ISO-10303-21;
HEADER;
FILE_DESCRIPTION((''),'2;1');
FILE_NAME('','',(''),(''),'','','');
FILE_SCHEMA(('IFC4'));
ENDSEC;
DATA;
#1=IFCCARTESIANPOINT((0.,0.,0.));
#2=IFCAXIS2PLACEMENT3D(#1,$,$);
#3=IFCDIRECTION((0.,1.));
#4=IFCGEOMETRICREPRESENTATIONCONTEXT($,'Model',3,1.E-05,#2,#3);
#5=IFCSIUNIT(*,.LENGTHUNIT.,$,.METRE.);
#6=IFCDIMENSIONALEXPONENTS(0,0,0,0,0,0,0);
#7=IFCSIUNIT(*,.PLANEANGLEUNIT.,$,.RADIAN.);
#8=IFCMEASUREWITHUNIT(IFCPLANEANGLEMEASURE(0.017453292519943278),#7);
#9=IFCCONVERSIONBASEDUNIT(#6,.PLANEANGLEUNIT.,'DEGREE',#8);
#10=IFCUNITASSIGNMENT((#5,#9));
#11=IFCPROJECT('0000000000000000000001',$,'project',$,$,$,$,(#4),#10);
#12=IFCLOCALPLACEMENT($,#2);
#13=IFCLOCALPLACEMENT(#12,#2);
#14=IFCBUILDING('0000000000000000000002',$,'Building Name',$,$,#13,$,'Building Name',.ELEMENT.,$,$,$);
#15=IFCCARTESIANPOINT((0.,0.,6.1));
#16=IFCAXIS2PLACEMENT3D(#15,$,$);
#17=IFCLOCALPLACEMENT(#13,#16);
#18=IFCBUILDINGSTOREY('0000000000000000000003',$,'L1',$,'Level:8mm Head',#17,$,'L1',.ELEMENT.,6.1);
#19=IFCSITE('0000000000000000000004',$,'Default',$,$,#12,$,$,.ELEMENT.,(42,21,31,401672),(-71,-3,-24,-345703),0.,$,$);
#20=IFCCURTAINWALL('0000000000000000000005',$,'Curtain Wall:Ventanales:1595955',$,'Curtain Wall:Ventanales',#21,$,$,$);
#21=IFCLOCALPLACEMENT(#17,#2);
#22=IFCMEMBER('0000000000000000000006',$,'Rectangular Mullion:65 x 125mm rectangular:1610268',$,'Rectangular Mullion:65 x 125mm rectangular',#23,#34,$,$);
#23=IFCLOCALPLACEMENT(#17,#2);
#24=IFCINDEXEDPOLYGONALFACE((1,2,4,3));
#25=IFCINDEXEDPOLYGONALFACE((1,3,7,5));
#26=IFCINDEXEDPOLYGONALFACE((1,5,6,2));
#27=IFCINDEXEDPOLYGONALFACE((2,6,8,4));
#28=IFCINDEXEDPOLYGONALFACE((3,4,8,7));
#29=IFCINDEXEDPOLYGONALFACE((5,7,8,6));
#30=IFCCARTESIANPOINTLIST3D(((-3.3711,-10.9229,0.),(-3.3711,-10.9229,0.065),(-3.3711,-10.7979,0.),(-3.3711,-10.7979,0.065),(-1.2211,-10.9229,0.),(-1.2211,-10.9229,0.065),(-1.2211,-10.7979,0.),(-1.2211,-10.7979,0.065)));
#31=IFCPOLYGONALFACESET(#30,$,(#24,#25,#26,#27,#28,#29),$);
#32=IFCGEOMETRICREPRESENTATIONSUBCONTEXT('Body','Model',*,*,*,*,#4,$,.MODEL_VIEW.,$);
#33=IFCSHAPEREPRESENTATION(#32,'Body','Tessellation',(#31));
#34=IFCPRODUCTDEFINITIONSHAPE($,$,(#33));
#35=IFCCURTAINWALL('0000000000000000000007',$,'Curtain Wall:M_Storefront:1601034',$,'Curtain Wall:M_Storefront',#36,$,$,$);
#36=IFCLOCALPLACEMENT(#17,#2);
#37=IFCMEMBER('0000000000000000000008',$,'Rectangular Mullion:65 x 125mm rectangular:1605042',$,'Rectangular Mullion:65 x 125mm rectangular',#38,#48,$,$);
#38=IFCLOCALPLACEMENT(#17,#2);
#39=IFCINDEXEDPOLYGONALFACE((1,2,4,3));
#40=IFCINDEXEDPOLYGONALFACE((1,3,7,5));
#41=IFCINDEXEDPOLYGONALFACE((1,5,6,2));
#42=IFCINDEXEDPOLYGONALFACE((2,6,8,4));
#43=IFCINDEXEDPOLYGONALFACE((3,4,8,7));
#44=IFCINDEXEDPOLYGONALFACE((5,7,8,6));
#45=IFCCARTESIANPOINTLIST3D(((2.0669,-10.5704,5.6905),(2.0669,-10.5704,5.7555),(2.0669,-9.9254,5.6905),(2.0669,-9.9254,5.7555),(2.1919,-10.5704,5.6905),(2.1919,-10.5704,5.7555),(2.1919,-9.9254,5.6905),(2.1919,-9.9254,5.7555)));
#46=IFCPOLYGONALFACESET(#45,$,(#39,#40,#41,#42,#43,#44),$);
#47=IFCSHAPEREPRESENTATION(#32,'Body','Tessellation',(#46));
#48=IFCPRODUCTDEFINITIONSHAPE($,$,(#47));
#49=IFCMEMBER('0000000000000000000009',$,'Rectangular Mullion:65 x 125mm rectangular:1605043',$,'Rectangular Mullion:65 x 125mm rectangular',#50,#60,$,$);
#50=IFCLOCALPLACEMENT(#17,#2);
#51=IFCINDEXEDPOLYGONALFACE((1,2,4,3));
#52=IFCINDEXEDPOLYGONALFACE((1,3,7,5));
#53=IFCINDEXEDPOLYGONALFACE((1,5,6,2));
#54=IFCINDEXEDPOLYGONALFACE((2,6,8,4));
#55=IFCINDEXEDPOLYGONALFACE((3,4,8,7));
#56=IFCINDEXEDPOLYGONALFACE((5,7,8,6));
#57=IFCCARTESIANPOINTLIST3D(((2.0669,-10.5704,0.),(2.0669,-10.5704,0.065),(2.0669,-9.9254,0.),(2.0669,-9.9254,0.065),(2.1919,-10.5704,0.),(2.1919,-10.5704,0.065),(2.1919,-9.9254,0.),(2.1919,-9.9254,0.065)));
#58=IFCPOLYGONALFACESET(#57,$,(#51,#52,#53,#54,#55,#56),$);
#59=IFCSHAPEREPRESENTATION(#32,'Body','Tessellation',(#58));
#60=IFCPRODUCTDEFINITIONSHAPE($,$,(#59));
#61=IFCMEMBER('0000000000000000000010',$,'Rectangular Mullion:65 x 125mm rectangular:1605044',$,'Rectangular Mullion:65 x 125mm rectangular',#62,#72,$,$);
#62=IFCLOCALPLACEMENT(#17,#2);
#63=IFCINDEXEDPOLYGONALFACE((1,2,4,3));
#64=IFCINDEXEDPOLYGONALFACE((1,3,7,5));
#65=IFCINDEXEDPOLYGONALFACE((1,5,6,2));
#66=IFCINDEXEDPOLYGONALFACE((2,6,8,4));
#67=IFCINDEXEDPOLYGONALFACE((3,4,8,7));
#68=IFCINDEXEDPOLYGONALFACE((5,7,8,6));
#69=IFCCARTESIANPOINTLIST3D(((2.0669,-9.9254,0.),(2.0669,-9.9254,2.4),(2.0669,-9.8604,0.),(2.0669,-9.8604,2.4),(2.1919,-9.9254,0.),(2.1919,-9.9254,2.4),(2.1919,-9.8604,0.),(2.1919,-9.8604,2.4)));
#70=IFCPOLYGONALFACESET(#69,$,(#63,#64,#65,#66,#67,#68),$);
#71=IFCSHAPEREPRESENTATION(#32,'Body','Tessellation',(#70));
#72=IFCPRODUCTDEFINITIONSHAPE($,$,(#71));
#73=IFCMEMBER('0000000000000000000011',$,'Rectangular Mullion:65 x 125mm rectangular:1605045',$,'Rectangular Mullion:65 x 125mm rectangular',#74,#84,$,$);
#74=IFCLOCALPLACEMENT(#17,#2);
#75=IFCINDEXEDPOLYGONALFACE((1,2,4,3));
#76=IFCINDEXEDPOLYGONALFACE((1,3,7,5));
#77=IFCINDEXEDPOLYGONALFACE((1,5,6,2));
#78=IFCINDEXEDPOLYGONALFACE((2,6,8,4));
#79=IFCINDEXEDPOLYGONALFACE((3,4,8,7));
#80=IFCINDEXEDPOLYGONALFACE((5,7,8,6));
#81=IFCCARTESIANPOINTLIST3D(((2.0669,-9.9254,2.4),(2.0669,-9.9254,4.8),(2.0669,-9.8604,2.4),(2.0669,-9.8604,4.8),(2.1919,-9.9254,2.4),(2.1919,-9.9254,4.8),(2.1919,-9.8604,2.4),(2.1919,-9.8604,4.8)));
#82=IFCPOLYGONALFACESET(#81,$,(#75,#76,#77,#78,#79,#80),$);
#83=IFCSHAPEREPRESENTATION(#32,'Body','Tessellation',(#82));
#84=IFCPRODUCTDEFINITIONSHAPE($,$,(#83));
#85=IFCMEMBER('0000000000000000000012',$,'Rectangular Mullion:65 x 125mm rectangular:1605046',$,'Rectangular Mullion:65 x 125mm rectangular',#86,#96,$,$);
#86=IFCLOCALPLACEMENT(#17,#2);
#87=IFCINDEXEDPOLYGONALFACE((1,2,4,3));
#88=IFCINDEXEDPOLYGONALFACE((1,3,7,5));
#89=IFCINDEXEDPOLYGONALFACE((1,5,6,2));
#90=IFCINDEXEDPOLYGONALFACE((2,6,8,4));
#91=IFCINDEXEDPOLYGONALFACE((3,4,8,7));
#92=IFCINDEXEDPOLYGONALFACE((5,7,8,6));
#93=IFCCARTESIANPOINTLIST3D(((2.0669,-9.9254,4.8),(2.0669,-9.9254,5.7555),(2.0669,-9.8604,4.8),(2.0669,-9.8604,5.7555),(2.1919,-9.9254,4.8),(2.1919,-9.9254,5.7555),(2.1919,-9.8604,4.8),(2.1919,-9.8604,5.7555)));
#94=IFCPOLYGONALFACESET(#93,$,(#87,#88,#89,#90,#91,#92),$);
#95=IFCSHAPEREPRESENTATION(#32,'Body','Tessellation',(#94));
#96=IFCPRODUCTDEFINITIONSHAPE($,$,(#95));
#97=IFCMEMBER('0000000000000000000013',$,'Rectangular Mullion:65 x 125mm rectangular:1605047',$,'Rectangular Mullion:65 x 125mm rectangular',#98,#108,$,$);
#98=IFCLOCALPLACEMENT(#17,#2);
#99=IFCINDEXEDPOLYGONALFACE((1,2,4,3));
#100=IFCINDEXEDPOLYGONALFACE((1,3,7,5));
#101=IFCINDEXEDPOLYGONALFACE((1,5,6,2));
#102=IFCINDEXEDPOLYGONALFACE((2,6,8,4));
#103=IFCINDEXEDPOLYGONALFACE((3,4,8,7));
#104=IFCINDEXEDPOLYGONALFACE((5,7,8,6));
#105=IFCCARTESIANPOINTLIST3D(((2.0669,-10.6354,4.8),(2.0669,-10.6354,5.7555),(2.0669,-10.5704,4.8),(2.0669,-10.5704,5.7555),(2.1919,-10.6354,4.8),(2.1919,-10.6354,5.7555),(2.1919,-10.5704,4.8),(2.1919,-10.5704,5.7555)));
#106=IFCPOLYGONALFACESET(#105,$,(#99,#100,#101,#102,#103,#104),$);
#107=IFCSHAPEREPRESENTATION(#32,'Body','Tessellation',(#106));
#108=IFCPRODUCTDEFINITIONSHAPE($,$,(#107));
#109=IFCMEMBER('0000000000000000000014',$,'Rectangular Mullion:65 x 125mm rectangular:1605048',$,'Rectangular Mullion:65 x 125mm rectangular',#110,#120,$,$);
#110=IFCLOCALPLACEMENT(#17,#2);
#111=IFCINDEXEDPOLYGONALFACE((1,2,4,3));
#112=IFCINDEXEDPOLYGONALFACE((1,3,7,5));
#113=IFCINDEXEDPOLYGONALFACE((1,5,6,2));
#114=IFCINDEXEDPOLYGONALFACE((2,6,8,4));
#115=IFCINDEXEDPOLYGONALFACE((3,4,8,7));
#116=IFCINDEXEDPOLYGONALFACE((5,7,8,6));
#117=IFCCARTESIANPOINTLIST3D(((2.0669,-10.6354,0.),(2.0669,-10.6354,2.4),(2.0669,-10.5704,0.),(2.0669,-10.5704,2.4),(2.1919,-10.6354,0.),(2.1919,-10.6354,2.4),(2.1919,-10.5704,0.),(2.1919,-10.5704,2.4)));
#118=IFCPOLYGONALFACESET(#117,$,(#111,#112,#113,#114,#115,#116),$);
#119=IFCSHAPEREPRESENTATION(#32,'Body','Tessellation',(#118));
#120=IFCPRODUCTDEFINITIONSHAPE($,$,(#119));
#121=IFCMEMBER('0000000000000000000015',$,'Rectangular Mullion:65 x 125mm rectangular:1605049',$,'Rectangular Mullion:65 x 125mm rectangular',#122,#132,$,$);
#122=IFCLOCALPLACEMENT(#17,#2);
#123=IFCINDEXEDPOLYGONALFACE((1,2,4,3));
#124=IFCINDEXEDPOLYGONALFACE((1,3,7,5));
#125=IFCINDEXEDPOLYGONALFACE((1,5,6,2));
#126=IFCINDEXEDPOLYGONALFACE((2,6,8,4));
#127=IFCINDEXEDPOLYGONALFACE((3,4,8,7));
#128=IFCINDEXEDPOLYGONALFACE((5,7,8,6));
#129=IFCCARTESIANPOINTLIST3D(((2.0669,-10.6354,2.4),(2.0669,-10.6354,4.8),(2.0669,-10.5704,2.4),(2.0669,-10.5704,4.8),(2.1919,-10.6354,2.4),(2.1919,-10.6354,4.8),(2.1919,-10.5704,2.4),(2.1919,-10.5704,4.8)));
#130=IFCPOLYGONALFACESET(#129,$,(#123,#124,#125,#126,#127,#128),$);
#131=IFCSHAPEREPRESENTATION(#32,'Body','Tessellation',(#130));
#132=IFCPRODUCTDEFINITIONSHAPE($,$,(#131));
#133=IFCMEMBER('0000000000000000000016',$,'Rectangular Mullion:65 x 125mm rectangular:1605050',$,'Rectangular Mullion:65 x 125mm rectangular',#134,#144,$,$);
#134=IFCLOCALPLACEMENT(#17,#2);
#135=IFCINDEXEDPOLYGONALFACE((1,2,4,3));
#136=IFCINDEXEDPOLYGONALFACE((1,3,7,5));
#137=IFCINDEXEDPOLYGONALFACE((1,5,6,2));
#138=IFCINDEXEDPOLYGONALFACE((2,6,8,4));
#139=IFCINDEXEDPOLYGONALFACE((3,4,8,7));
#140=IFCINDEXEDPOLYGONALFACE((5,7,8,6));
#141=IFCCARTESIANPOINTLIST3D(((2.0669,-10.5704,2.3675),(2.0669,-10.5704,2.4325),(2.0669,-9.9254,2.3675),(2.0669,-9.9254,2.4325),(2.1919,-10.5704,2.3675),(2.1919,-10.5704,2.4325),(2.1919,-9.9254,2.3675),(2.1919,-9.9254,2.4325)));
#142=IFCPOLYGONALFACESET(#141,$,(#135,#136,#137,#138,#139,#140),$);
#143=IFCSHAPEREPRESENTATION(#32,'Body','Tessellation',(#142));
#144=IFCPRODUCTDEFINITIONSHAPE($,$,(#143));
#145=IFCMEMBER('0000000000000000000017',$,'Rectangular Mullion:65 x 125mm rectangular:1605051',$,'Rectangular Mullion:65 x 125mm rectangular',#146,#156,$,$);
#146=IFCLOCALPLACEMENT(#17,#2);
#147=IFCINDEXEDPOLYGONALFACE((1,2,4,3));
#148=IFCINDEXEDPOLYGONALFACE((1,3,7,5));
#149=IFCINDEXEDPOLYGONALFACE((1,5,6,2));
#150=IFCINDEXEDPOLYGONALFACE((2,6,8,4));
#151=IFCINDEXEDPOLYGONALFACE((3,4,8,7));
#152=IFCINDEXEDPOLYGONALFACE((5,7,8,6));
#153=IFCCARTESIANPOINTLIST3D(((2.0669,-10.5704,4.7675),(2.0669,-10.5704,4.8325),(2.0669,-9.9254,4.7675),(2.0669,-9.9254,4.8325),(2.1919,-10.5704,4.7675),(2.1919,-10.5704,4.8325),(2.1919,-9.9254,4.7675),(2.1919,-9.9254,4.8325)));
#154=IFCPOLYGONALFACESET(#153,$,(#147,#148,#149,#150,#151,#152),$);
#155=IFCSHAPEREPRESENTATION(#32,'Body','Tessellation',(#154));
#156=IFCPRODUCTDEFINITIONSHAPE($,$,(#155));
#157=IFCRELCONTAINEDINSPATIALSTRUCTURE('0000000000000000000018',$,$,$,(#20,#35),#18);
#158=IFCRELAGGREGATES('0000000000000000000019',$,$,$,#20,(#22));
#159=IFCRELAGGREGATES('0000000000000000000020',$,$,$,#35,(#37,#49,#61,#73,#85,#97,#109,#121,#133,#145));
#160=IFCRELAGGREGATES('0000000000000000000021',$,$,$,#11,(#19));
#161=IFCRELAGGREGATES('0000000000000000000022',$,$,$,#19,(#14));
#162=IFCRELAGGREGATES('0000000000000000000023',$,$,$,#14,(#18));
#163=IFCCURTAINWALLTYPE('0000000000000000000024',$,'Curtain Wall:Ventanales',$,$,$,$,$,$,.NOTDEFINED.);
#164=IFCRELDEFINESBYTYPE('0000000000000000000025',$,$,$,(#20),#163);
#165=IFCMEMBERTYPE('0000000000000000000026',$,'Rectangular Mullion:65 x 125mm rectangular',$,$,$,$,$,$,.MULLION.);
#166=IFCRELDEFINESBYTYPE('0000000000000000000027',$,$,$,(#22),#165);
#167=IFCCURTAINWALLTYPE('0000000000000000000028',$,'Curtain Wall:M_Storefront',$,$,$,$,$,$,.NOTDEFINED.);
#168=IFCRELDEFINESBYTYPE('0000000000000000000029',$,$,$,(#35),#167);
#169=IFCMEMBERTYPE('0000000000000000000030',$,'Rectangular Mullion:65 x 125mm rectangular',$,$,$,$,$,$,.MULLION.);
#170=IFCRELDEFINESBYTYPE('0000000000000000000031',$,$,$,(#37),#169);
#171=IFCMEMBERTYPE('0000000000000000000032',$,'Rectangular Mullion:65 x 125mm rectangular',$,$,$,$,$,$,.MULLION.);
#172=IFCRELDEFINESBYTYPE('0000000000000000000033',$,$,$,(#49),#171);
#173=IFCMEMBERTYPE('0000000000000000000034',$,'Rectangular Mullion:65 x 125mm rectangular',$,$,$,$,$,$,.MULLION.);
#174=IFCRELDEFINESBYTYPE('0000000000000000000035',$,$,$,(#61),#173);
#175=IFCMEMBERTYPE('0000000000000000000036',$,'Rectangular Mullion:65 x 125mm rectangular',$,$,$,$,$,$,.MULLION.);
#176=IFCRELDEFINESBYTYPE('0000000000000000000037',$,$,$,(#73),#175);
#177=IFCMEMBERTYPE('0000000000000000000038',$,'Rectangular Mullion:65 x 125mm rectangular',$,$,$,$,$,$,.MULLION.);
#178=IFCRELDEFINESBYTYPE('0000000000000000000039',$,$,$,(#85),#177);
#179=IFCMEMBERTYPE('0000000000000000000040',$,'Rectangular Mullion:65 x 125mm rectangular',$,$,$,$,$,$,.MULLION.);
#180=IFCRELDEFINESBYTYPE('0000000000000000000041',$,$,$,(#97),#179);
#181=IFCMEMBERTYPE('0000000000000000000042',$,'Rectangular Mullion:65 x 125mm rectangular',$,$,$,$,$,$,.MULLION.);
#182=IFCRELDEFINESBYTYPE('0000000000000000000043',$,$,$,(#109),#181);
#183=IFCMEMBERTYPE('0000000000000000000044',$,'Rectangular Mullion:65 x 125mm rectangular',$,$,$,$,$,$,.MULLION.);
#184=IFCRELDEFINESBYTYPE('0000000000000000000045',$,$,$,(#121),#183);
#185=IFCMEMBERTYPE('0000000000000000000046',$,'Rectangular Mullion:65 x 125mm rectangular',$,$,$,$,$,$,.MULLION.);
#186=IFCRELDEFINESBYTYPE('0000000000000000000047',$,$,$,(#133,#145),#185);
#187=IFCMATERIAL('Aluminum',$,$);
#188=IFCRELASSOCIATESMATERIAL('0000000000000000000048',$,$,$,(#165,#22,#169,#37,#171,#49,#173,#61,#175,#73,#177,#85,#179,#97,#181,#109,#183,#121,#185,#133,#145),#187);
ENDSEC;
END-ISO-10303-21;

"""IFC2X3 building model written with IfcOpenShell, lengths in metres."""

from ifc_helpers import new_model, entity, si_unit, converted_unit, direction, frame, frame_2d, origin, origin_2d_with_axis, place, context, subcontext, project, spatial, rectangle, extrude, source, transform, mapped, material, type_object, type_shapes, element, aggregate, save


model = new_model("IFC2X3")

# Units and contexts
model_context = context("Model", 3, precision=1e-05, world=origin(), true_north=direction((0.0, 1.0)))
body_context = subcontext(model_context, "Body", "Model", "MODEL_VIEW")
ifc_project = project(units=[si_unit("LENGTHUNIT", "METRE"), converted_unit("PLANEANGLEUNIT", "DEGREE", entity("IfcPlaneAngleMeasure", 0.017453292519943278), si_unit("PLANEANGLEUNIT", "RADIAN"), dimensions=[0, 0, 0, 0, 0, 0, 0])], contexts=[model_context])

# Site, building, storey
site_placement = place(None, origin())
site = spatial("IfcSite", under=ifc_project, at=site_placement, Name="Default", CompositionType="ELEMENT", RefLatitude=(42, 21, 31, 401672), RefLongitude=(-71, -3, -24, -345703), RefElevation=0.0)
building_placement = place(site_placement, origin())
building = spatial("IfcBuilding", under=site, at=building_placement, Name="Building Name", LongName="Building Name", CompositionType="ELEMENT")
storey_placement = place(building_placement, frame((0.0, 0.0, 6.1)))
storey = spatial("IfcBuildingStorey", under=building, at=storey_placement, Name="L1", ObjectType="Level:8mm Head", LongName="L1", CompositionType="ELEMENT", Elevation=6.1)

# Curtain wall, member
curtain_wall_type_1 = type_object("IfcCurtainWallType", Name="Curtain Wall:Ventanales", PredefinedType="NOTDEFINED")
curtain_wall_1_placement = place(storey_placement, frame((0.0, 0.0, -6.1)))
curtain_wall_1 = element("IfcCurtainWall", 1, at=curtain_wall_1_placement, inside=storey, type_object=curtain_wall_type_1, Name="Curtain Wall:Ventanales:1595955", ObjectType="Curtain Wall:Ventanales")
ifc_material_1 = material(Name="Aluminum")
member_type_1 = type_object("IfcMemberType", Name="Rectangular Mullion:65 x 125mm rectangular", PredefinedType="MULLION", material=ifc_material_1)
shared_shape_1 = source(origin(), body_context, "Body", "SweptSolid", [
    extrude(rectangle(XDim=0.065, YDim=0.125, at=origin_2d_with_axis()), frame((-0.0325, 0.0, -2.15), z_axis=(0.0, 0.0, 1.0), x_axis=(-1.0, 0.0, 0.0)), (0.0, 0.0, 1.0), 2.15),
])
type_shapes(member_type_1, [shared_shape_1])
member_1_placement = place(curtain_wall_1_placement, frame((-1.2211, -10.8604, 6.1), z_axis=(1.0, 0.0, 0.0), x_axis=(0.0, 0.0, -1.0)))
member_1 = element("IfcMember", 2, at=member_1_placement, type_object=member_type_1, material=ifc_material_1, Name="Rectangular Mullion:65 x 125mm rectangular:1610268", ObjectType="Rectangular Mullion:65 x 125mm rectangular", context=body_context, shape_type="MappedRepresentation", body=[
    mapped(shared_shape_1, transform((0.0, 0.0, 0.0), scale=1.0)),
])

# Curtain wall, members
curtain_wall_type_2 = type_object("IfcCurtainWallType", Name="Curtain Wall:M_Storefront", PredefinedType="NOTDEFINED")
curtain_wall_2_placement = place(storey_placement, frame((0.0, 0.0, -6.1)))
curtain_wall_2 = element("IfcCurtainWall", 3, at=curtain_wall_2_placement, inside=storey, type_object=curtain_wall_type_2, Name="Curtain Wall:M_Storefront:1601034", ObjectType="Curtain Wall:M_Storefront")
member_type_2 = type_object("IfcMemberType", Name="Rectangular Mullion:65 x 125mm rectangular", PredefinedType="MULLION", material=ifc_material_1)
shared_shape_2 = source(origin(), body_context, "Body", "SweptSolid", [
    extrude(rectangle(XDim=0.065, YDim=0.125, at=origin_2d_with_axis()), frame((-0.0325, 0.0, -0.645), z_axis=(0.0, 0.0, 1.0), x_axis=(-1.0, 0.0, 0.0)), (0.0, 0.0, 1.0), 0.645),
])
type_shapes(member_type_2, [shared_shape_2])
member_2_placement = place(curtain_wall_2_placement, frame((2.1294, -9.9254, 11.8555), z_axis=(0.0, 1.0, 0.0), x_axis=(0.0, 0.0, 1.0)))
member_2 = element("IfcMember", 4, at=member_2_placement, type_object=member_type_2, material=ifc_material_1, Name="Rectangular Mullion:65 x 125mm rectangular:1605042", ObjectType="Rectangular Mullion:65 x 125mm rectangular", context=body_context, shape_type="MappedRepresentation", body=[
    mapped(shared_shape_2, transform((0.0, 0.0, 0.0), scale=1.0)),
])
member_type_3 = type_object("IfcMemberType", Name="Rectangular Mullion:65 x 125mm rectangular", PredefinedType="MULLION", material=ifc_material_1)
shared_shape_3 = source(origin(), body_context, "Body", "SweptSolid", [
    extrude(rectangle(XDim=0.065, YDim=0.125, at=origin_2d_with_axis()), frame((-0.0325, 0.0, -0.645), z_axis=(0.0, 0.0, 1.0), x_axis=(-1.0, 0.0, 0.0)), (0.0, 0.0, 1.0), 0.645),
])
type_shapes(member_type_3, [shared_shape_3])
member_3_placement = place(curtain_wall_2_placement, frame((2.1294, -10.5704, 6.1), z_axis=(0.0, -1.0, 0.0), x_axis=(0.0, 0.0, -1.0)))
member_3 = element("IfcMember", 5, at=member_3_placement, type_object=member_type_3, material=ifc_material_1, Name="Rectangular Mullion:65 x 125mm rectangular:1605043", ObjectType="Rectangular Mullion:65 x 125mm rectangular", context=body_context, shape_type="MappedRepresentation", body=[
    mapped(shared_shape_3, transform((0.0, 0.0, 0.0), scale=1.0)),
])
member_type_4 = type_object("IfcMemberType", Name="Rectangular Mullion:65 x 125mm rectangular", PredefinedType="MULLION", material=ifc_material_1)
shared_shape_4 = source(origin(), body_context, "Body", "SweptSolid", [
    extrude(rectangle(XDim=0.065, YDim=0.125, at=origin_2d_with_axis()), frame((-0.0325, 0.0, -2.4), z_axis=(0.0, 0.0, 1.0), x_axis=(-1.0, 0.0, 0.0)), (0.0, 0.0, 1.0), 2.4),
])
type_shapes(member_type_4, [shared_shape_4])
member_4_placement = place(curtain_wall_2_placement, frame((2.1294, -9.8604, 6.1), z_axis=(0.0, 0.0, -1.0), x_axis=(0.0, 1.0, 0.0)))
member_4 = element("IfcMember", 6, at=member_4_placement, type_object=member_type_4, material=ifc_material_1, Name="Rectangular Mullion:65 x 125mm rectangular:1605044", ObjectType="Rectangular Mullion:65 x 125mm rectangular", context=body_context, shape_type="MappedRepresentation", body=[
    mapped(shared_shape_4, transform((0.0, 0.0, 0.0), scale=1.0)),
])
member_type_5 = type_object("IfcMemberType", Name="Rectangular Mullion:65 x 125mm rectangular", PredefinedType="MULLION", material=ifc_material_1)
shared_shape_5 = source(origin(), body_context, "Body", "SweptSolid", [
    extrude(rectangle(XDim=0.065, YDim=0.125, at=origin_2d_with_axis()), frame((-0.0325, 0.0, -2.4), z_axis=(0.0, 0.0, 1.0), x_axis=(-1.0, 0.0, 0.0)), (0.0, 0.0, 1.0), 2.4),
])
type_shapes(member_type_5, [shared_shape_5])
member_5_placement = place(curtain_wall_2_placement, frame((2.1294, -9.8604, 8.5), z_axis=(0.0, 0.0, -1.0), x_axis=(0.0, 1.0, 0.0)))
member_5 = element("IfcMember", 7, at=member_5_placement, type_object=member_type_5, material=ifc_material_1, Name="Rectangular Mullion:65 x 125mm rectangular:1605045", ObjectType="Rectangular Mullion:65 x 125mm rectangular", context=body_context, shape_type="MappedRepresentation", body=[
    mapped(shared_shape_5, transform((0.0, 0.0, 0.0), scale=1.0)),
])
member_type_6 = type_object("IfcMemberType", Name="Rectangular Mullion:65 x 125mm rectangular", PredefinedType="MULLION", material=ifc_material_1)
shared_shape_6 = source(origin(), body_context, "Body", "SweptSolid", [
    extrude(rectangle(XDim=0.065, YDim=0.125, at=origin_2d_with_axis()), frame((-0.0325, 0.0, -0.9555), z_axis=(0.0, 0.0, 1.0), x_axis=(-1.0, 0.0, 0.0)), (0.0, 0.0, 1.0), 0.9555),
])
type_shapes(member_type_6, [shared_shape_6])
member_6_placement = place(curtain_wall_2_placement, frame((2.1294, -9.8604, 10.9), z_axis=(0.0, 0.0, -1.0), x_axis=(0.0, 1.0, 0.0)))
member_6 = element("IfcMember", 8, at=member_6_placement, type_object=member_type_6, material=ifc_material_1, Name="Rectangular Mullion:65 x 125mm rectangular:1605046", ObjectType="Rectangular Mullion:65 x 125mm rectangular", context=body_context, shape_type="MappedRepresentation", body=[
    mapped(shared_shape_6, transform((0.0, 0.0, 0.0), scale=1.0)),
])
member_type_7 = type_object("IfcMemberType", Name="Rectangular Mullion:65 x 125mm rectangular", PredefinedType="MULLION", material=ifc_material_1)
shared_shape_7 = source(origin(), body_context, "Body", "SweptSolid", [
    extrude(rectangle(XDim=0.065, YDim=0.125, at=origin_2d_with_axis()), frame((-0.0325, 0.0, -0.9555), z_axis=(0.0, 0.0, 1.0), x_axis=(-1.0, 0.0, 0.0)), (0.0, 0.0, 1.0), 0.9555),
])
type_shapes(member_type_7, [shared_shape_7])
member_7_placement = place(curtain_wall_2_placement, frame((2.1294, -10.6354, 11.8555), z_axis=(0.0, 0.0, 1.0), x_axis=(0.0, -1.0, 0.0)))
member_7 = element("IfcMember", 9, at=member_7_placement, type_object=member_type_7, material=ifc_material_1, Name="Rectangular Mullion:65 x 125mm rectangular:1605047", ObjectType="Rectangular Mullion:65 x 125mm rectangular", context=body_context, shape_type="MappedRepresentation", body=[
    mapped(shared_shape_7, transform((0.0, 0.0, 0.0), scale=1.0)),
])
member_type_8 = type_object("IfcMemberType", Name="Rectangular Mullion:65 x 125mm rectangular", PredefinedType="MULLION", material=ifc_material_1)
shared_shape_8 = source(origin(), body_context, "Body", "SweptSolid", [
    extrude(rectangle(XDim=0.065, YDim=0.125, at=origin_2d_with_axis()), frame((-0.0325, 0.0, -2.4), z_axis=(0.0, 0.0, 1.0), x_axis=(-1.0, 0.0, 0.0)), (0.0, 0.0, 1.0), 2.4),
])
type_shapes(member_type_8, [shared_shape_8])
member_8_placement = place(curtain_wall_2_placement, frame((2.1294, -10.6354, 8.5), z_axis=(0.0, 0.0, 1.0), x_axis=(0.0, -1.0, 0.0)))
member_8 = element("IfcMember", 10, at=member_8_placement, type_object=member_type_8, material=ifc_material_1, Name="Rectangular Mullion:65 x 125mm rectangular:1605048", ObjectType="Rectangular Mullion:65 x 125mm rectangular", context=body_context, shape_type="MappedRepresentation", body=[
    mapped(shared_shape_8, transform((0.0, 0.0, 0.0), scale=1.0)),
])
member_type_9 = type_object("IfcMemberType", Name="Rectangular Mullion:65 x 125mm rectangular", PredefinedType="MULLION", material=ifc_material_1)
shared_shape_9 = source(origin(), body_context, "Body", "SweptSolid", [
    extrude(rectangle(XDim=0.065, YDim=0.125, at=origin_2d_with_axis()), frame((-0.0325, 0.0, -2.4), z_axis=(0.0, 0.0, 1.0), x_axis=(-1.0, 0.0, 0.0)), (0.0, 0.0, 1.0), 2.4),
])
type_shapes(member_type_9, [shared_shape_9])
member_9_placement = place(curtain_wall_2_placement, frame((2.1294, -10.6354, 10.9), z_axis=(0.0, 0.0, 1.0), x_axis=(0.0, -1.0, 0.0)))
member_9 = element("IfcMember", 11, at=member_9_placement, type_object=member_type_9, material=ifc_material_1, Name="Rectangular Mullion:65 x 125mm rectangular:1605049", ObjectType="Rectangular Mullion:65 x 125mm rectangular", context=body_context, shape_type="MappedRepresentation", body=[
    mapped(shared_shape_9, transform((0.0, 0.0, 0.0), scale=1.0)),
])
member_type_10 = type_object("IfcMemberType", Name="Rectangular Mullion:65 x 125mm rectangular", PredefinedType="MULLION", material=ifc_material_1)
shared_shape_10 = source(origin(), body_context, "Body", "SweptSolid", [
    extrude(rectangle(XDim=0.065, YDim=0.125, at=frame_2d((0.0, 0.0), x_axis=(1.0, 0.0))), frame((0.0, 0.0, -0.645), z_axis=(0.0, 0.0, 1.0), x_axis=(-1.0, 0.0, 0.0)), (0.0, 0.0, 1.0), 0.645),
])
type_shapes(member_type_10, [shared_shape_10])
member_10_placement = place(curtain_wall_2_placement, frame((2.1294, -9.9254, 8.5), z_axis=(0.0, 1.0, 0.0), x_axis=(0.0, 0.0, 1.0)))
member_10 = element("IfcMember", 12, at=member_10_placement, type_object=member_type_10, material=ifc_material_1, Name="Rectangular Mullion:65 x 125mm rectangular:1605050", ObjectType="Rectangular Mullion:65 x 125mm rectangular", context=body_context, shape_type="MappedRepresentation", body=[
    mapped(shared_shape_10, transform((0.0, 0.0, 0.0), scale=1.0)),
])
member_11_placement = place(curtain_wall_2_placement, frame((2.1294, -9.9254, 10.9), z_axis=(0.0, 1.0, 0.0), x_axis=(0.0, 0.0, 1.0)))
member_11 = element("IfcMember", 13, at=member_11_placement, type_object=member_type_10, material=ifc_material_1, Name="Rectangular Mullion:65 x 125mm rectangular:1605051", ObjectType="Rectangular Mullion:65 x 125mm rectangular", context=body_context, shape_type="MappedRepresentation", body=[
    mapped(shared_shape_10, transform((0.0, 0.0, 0.0), scale=1.0)),
])

aggregate(curtain_wall_1, [member_1])
aggregate(curtain_wall_2, [member_2, member_3, member_4, member_5, member_6, member_7, member_8, member_9, member_10, member_11])

save(model, "model.ifc")
